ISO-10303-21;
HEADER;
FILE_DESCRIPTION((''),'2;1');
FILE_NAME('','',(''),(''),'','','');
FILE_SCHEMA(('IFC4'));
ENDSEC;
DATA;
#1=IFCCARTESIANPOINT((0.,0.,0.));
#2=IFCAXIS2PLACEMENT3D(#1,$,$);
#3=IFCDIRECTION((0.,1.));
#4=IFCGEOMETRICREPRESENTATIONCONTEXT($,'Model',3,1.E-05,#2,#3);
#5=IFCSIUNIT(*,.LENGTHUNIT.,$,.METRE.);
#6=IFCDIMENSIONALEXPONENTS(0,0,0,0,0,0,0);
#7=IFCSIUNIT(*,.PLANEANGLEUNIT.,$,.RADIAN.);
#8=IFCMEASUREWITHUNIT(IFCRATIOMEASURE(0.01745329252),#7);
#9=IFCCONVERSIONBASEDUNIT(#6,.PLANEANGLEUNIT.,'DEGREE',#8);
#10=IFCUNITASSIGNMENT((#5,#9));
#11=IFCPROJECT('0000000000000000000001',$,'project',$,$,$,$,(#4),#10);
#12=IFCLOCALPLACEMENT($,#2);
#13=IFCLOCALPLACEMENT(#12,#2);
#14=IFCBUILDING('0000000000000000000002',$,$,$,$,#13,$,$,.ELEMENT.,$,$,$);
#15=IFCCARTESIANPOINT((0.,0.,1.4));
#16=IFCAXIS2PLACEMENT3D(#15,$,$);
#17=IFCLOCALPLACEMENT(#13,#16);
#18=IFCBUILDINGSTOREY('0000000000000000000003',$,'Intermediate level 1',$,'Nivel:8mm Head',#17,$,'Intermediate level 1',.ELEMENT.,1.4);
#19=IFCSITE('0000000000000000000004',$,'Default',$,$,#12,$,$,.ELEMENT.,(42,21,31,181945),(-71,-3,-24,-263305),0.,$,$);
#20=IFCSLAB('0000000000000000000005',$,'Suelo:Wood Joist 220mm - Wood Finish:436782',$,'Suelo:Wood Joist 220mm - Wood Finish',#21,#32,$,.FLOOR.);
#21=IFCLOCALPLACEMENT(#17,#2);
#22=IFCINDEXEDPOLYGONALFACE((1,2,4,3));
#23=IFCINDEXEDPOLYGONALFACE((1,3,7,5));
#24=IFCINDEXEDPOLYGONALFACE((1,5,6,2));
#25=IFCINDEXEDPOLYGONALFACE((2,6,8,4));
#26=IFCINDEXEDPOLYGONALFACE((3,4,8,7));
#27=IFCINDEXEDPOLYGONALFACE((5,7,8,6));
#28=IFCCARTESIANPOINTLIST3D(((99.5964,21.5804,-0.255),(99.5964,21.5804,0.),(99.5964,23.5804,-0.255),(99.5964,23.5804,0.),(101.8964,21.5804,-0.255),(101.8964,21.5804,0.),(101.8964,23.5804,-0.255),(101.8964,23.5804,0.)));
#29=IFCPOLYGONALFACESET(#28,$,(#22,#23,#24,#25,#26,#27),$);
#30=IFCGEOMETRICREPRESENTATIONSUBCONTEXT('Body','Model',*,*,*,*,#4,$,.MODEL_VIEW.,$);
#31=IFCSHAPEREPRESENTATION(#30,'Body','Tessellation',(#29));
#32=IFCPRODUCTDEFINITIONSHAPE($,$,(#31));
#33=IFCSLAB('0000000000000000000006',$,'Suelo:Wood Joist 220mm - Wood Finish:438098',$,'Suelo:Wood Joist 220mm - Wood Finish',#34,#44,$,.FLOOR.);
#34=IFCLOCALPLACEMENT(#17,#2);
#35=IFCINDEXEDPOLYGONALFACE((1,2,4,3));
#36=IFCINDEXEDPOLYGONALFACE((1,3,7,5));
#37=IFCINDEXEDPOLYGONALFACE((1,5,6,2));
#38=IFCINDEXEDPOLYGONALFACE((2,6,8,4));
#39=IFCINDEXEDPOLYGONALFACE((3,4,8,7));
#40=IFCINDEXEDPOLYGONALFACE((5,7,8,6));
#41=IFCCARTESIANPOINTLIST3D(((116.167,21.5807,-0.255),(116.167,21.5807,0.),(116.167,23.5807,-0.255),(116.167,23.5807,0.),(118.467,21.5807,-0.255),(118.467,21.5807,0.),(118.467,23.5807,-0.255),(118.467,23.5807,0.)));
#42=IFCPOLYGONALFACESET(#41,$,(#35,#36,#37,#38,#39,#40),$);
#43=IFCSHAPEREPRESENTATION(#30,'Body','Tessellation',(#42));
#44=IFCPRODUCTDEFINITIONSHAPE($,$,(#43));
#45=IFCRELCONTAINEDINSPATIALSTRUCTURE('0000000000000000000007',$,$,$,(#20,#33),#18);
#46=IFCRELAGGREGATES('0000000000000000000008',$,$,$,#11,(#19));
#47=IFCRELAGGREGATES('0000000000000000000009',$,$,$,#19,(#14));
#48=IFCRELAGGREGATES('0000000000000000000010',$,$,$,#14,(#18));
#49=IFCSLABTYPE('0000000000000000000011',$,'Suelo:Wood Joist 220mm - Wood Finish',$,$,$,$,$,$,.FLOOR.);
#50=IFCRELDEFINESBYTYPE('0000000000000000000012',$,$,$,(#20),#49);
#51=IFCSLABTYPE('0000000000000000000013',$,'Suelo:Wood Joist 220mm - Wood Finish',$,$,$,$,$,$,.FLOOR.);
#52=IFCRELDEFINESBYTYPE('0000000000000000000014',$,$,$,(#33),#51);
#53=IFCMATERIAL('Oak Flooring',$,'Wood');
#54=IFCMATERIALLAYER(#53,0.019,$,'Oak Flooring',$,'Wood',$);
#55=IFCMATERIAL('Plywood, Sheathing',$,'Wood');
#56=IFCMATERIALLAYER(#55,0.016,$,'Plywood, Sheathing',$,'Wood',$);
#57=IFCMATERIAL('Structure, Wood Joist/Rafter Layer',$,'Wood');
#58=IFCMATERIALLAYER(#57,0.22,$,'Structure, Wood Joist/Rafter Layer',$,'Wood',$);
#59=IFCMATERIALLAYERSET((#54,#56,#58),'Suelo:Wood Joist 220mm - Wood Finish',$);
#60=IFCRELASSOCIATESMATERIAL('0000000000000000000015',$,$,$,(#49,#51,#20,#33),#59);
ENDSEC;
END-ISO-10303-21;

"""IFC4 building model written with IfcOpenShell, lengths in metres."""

from ifc_helpers import new_model, entity, si_unit, converted_unit, direction, frame, origin, origin_2d_with_axis, place, context, subcontext, project, spatial, rectangle, extrude, material, layer, layer_set, layer_usage, type_object, element, save


model = new_model("IFC4")

# Units and contexts
model_context = context("Model", 3, precision=1e-05, world=origin(), true_north=direction((0.0, 1.0)))
body_context = subcontext(model_context, "Body", "Model", "MODEL_VIEW")
ifc_project = project(units=[si_unit("LENGTHUNIT", "METRE"), converted_unit("PLANEANGLEUNIT", "DEGREE", entity("IfcRatioMeasure", 0.01745329252), si_unit("PLANEANGLEUNIT", "RADIAN"), dimensions=[0, 0, 0, 0, 0, 0, 0])], contexts=[model_context])

# Site, building, storey
site_placement = place(None, origin())
site = spatial("IfcSite", under=ifc_project, at=site_placement, Name="Default", CompositionType="ELEMENT", RefLatitude=(42, 21, 31, 181945), RefLongitude=(-71, -3, -24, -263305), RefElevation=0.0)
building_placement = place(site_placement, origin())
building = spatial("IfcBuilding", under=site, at=building_placement, CompositionType="ELEMENT")
storey_placement = place(building_placement, frame((0.0, 0.0, 1.4)))
storey = spatial("IfcBuildingStorey", under=building, at=storey_placement, Name="Intermediate level 1", ObjectType="Nivel:8mm Head", LongName="Intermediate level 1", CompositionType="ELEMENT", Elevation=1.4)

# Slabs
ifc_material_1 = material(Name="Oak Flooring", Category="Wood")
ifc_layer_1 = layer(ifc_material_1, 0.019, Name="Oak Flooring", Category="Wood")
ifc_material_2 = material(Name="Plywood, Sheathing", Category="Wood")
ifc_layer_2 = layer(ifc_material_2, 0.016, Name="Plywood, Sheathing", Category="Wood")
ifc_material_3 = material(Name="Structure, Wood Joist/Rafter Layer", Category="Wood")
ifc_layer_3 = layer(ifc_material_3, 0.22, Name="Structure, Wood Joist/Rafter Layer", Category="Wood")
ifc_layer_set = layer_set([ifc_layer_1, ifc_layer_2, ifc_layer_3], Name="Suelo:Wood Joist 220mm - Wood Finish")
ifc_layer_usage_1 = layer_usage(ifc_layer_set, "AXIS3", "POSITIVE", 0.0)
slab_type_1 = type_object("IfcSlabType", Name="Suelo:Wood Joist 220mm - Wood Finish", PredefinedType="FLOOR", material=ifc_layer_set)
slab_1_placement = place(storey_placement, origin())
element("IfcSlab", 1, at=slab_1_placement, inside=storey, type_object=slab_type_1, material=ifc_layer_usage_1, Name="Suelo:Wood Joist 220mm - Wood Finish:436782", ObjectType="Suelo:Wood Joist 220mm - Wood Finish", PredefinedType="FLOOR", context=body_context, shape_type="SweptSolid", body=[
    extrude(rectangle(XDim=2.0, YDim=2.3, at=origin_2d_with_axis()), frame((100.7464, 22.5804, 0.0), z_axis=(0.0, 0.0, -1.0), x_axis=(0.0, 1.0, 0.0)), (0.0, 0.0, 1.0), 0.255),
])
ifc_layer_usage_2 = layer_usage(ifc_layer_set, "AXIS3", "POSITIVE", 0.0)
slab_type_2 = type_object("IfcSlabType", Name="Suelo:Wood Joist 220mm - Wood Finish", PredefinedType="FLOOR", material=ifc_layer_set)
slab_2_placement = place(storey_placement, origin())
element("IfcSlab", 2, at=slab_2_placement, inside=storey, type_object=slab_type_2, material=ifc_layer_usage_2, Name="Suelo:Wood Joist 220mm - Wood Finish:438098", ObjectType="Suelo:Wood Joist 220mm - Wood Finish", PredefinedType="FLOOR", context=body_context, shape_type="SweptSolid", body=[
    extrude(rectangle(XDim=2.0, YDim=2.3, at=origin_2d_with_axis()), frame((117.317, 22.5807, 0.0), z_axis=(0.0, 0.0, -1.0), x_axis=(0.0, 1.0, 0.0)), (0.0, 0.0, 1.0), 0.255),
])

save(model, "model.ifc")
